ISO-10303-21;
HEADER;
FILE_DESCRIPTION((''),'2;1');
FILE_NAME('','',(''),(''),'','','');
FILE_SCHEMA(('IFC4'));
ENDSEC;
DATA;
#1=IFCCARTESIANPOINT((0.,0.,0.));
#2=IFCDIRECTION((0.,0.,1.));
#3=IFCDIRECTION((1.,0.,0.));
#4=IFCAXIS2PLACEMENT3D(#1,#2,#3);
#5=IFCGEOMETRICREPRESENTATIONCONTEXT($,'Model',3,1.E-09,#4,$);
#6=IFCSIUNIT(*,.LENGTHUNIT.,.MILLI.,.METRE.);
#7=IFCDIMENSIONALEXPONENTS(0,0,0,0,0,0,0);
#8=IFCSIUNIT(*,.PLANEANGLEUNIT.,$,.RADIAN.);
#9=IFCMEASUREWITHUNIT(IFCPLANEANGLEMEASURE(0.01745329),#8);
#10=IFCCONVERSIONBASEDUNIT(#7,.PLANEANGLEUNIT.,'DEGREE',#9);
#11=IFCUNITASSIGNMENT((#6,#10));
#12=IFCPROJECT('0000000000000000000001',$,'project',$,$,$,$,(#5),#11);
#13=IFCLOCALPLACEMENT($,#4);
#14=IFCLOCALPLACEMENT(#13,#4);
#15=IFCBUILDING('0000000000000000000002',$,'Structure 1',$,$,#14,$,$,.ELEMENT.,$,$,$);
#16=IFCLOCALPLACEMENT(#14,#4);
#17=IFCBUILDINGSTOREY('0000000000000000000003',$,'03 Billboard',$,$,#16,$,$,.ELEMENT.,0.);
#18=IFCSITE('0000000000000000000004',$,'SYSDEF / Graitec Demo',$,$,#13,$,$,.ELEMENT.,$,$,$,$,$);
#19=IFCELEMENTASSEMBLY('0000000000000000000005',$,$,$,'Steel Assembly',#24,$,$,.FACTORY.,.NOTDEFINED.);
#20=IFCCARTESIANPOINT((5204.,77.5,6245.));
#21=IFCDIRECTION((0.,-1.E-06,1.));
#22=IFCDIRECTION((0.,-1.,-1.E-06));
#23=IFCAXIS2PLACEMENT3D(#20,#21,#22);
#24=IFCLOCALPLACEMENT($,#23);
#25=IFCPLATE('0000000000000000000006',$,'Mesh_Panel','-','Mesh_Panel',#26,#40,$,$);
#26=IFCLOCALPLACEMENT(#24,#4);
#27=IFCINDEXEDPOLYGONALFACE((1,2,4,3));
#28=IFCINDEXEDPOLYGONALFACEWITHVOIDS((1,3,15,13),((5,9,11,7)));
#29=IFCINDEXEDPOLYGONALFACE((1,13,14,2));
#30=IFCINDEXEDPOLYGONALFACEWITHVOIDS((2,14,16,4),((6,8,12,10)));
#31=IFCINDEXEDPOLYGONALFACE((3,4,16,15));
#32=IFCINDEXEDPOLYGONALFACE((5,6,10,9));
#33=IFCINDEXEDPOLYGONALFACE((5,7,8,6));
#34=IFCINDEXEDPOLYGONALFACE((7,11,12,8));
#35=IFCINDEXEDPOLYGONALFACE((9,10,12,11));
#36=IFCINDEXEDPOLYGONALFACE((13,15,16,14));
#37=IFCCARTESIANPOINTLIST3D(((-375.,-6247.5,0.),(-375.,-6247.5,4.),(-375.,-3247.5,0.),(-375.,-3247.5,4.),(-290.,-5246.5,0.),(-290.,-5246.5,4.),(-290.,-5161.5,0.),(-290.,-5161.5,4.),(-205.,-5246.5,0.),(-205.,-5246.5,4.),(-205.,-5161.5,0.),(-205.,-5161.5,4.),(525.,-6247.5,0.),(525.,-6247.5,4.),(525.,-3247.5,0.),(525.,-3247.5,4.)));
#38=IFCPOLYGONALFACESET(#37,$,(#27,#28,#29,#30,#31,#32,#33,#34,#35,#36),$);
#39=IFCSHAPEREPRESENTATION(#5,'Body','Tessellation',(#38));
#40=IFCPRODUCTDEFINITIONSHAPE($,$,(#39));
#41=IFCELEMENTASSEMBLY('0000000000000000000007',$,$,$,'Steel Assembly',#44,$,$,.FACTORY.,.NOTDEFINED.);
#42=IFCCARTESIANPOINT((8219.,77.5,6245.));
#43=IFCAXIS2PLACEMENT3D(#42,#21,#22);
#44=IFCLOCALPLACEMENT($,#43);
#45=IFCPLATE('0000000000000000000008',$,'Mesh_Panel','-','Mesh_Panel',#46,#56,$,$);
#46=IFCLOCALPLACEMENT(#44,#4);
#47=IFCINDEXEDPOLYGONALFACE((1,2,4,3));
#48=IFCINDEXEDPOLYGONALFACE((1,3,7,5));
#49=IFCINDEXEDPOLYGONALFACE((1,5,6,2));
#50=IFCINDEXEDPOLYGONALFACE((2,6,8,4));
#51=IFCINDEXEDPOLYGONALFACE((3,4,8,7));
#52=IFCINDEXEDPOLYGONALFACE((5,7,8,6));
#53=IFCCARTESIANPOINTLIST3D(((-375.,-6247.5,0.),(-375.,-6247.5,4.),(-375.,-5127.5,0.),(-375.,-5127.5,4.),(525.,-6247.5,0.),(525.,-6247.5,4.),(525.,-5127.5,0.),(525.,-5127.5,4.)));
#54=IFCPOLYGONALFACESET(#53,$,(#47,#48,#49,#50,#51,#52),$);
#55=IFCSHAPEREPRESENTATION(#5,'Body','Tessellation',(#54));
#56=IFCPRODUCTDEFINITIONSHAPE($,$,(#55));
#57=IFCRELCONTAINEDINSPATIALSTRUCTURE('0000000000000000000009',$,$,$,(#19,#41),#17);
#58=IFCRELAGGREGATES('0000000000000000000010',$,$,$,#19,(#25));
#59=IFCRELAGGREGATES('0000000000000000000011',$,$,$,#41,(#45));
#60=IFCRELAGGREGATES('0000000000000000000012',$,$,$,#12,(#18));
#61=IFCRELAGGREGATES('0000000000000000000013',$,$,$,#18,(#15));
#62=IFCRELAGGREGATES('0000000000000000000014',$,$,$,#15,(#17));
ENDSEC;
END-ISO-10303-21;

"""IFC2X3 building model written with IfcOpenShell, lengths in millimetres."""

from ifc_helpers import new_model, entity, si_unit, converted_unit, frame, origin, origin_with_axes, place, context, project, spatial, polyline, outline, extrude, element, aggregate, save


model = new_model("IFC2X3")

# Units and contexts
model_context = context("Model", 3, precision=1e-09, world=origin_with_axes())
ifc_project = project(units=[si_unit("LENGTHUNIT", "METRE", prefix="MILLI"), converted_unit("PLANEANGLEUNIT", "DEGREE", entity("IfcPlaneAngleMeasure", 0.01745329), si_unit("PLANEANGLEUNIT", "RADIAN"), dimensions=[0, 0, 0, 0, 0, 0, 0])], contexts=[model_context])

# Site, building, storey
site_placement = place(None, origin_with_axes())
site = spatial("IfcSite", under=ifc_project, at=site_placement, Name="SYSDEF / Graitec Demo", CompositionType="ELEMENT")
building_placement = place(site_placement, origin_with_axes())
building = spatial("IfcBuilding", under=site, at=building_placement, Name="Structure 1", CompositionType="ELEMENT")
storey_placement = place(building_placement, origin_with_axes())
storey = spatial("IfcBuildingStorey", under=building, at=storey_placement, Name="03 Billboard", CompositionType="ELEMENT", Elevation=0.0)

# Element assembly, plate, opening
assembly_1_placement = place(None, frame((5204.0, 77.5, 6245.0), z_axis=(0.0, -0.000001, 1.0), x_axis=(0.0, -1.0, -0.000001)))
assembly_1 = element("IfcElementAssembly", 1, at=assembly_1_placement, inside=storey, ObjectType="Steel Assembly", AssemblyPlace="FACTORY", PredefinedType="NOTDEFINED")
plate_1_placement = place(assembly_1_placement, origin_with_axes())
plate_1 = element("IfcPlate", 2, at=plate_1_placement, Name="Mesh_Panel", Description="-", ObjectType="Mesh_Panel", context=model_context, shape_type="SweptSolid", body=[
    extrude(outline(polyline([(-375.0, -3247.5), (-375.0, -6247.5), (525.0, -6247.5), (525.0, -3247.5), (-375.0, -3247.5)])), origin_with_axes(), (0.0, 0.0, 1.0), 4.0),
])
opening_1_placement = place(plate_1_placement, frame((0.0, 0.0, -0.1), z_axis=(-0.000001, 0.0, 1.0), x_axis=(0.0, 1.0, 0.0)))
element("IfcOpeningElement", 3, at=opening_1_placement, cuts=plate_1, ObjectType="Opening", context=model_context, shape_type="SweptSolid", body=[
    extrude(outline(polyline([(-5246.5, 205.0), (-5161.5, 205.0), (-5161.5, 290.0), (-5246.5, 290.0), (-5246.5, 205.0)])), origin(), (0.0, 0.0, 1.0), 4.2),
])
aggregate(assembly_1, [plate_1])

# Element assembly, plate
assembly_2_placement = place(None, frame((8219.0, 77.5, 6245.0), z_axis=(0.0, -0.000001, 1.0), x_axis=(0.0, -1.0, -0.000001)))
assembly_2 = element("IfcElementAssembly", 4, at=assembly_2_placement, inside=storey, ObjectType="Steel Assembly", AssemblyPlace="FACTORY", PredefinedType="NOTDEFINED")
plate_2_placement = place(assembly_2_placement, origin_with_axes())
plate_2 = element("IfcPlate", 5, at=plate_2_placement, Name="Mesh_Panel", Description="-", ObjectType="Mesh_Panel", context=model_context, shape_type="SweptSolid", body=[
    extrude(outline(polyline([(-375.0, -5127.5), (-375.0, -6247.5), (525.0, -6247.5), (525.0, -5127.5), (-375.0, -5127.5)])), origin_with_axes(), (0.0, 0.0, 1.0), 4.0),
])
aggregate(assembly_2, [plate_2])

save(model, "model.ifc")
